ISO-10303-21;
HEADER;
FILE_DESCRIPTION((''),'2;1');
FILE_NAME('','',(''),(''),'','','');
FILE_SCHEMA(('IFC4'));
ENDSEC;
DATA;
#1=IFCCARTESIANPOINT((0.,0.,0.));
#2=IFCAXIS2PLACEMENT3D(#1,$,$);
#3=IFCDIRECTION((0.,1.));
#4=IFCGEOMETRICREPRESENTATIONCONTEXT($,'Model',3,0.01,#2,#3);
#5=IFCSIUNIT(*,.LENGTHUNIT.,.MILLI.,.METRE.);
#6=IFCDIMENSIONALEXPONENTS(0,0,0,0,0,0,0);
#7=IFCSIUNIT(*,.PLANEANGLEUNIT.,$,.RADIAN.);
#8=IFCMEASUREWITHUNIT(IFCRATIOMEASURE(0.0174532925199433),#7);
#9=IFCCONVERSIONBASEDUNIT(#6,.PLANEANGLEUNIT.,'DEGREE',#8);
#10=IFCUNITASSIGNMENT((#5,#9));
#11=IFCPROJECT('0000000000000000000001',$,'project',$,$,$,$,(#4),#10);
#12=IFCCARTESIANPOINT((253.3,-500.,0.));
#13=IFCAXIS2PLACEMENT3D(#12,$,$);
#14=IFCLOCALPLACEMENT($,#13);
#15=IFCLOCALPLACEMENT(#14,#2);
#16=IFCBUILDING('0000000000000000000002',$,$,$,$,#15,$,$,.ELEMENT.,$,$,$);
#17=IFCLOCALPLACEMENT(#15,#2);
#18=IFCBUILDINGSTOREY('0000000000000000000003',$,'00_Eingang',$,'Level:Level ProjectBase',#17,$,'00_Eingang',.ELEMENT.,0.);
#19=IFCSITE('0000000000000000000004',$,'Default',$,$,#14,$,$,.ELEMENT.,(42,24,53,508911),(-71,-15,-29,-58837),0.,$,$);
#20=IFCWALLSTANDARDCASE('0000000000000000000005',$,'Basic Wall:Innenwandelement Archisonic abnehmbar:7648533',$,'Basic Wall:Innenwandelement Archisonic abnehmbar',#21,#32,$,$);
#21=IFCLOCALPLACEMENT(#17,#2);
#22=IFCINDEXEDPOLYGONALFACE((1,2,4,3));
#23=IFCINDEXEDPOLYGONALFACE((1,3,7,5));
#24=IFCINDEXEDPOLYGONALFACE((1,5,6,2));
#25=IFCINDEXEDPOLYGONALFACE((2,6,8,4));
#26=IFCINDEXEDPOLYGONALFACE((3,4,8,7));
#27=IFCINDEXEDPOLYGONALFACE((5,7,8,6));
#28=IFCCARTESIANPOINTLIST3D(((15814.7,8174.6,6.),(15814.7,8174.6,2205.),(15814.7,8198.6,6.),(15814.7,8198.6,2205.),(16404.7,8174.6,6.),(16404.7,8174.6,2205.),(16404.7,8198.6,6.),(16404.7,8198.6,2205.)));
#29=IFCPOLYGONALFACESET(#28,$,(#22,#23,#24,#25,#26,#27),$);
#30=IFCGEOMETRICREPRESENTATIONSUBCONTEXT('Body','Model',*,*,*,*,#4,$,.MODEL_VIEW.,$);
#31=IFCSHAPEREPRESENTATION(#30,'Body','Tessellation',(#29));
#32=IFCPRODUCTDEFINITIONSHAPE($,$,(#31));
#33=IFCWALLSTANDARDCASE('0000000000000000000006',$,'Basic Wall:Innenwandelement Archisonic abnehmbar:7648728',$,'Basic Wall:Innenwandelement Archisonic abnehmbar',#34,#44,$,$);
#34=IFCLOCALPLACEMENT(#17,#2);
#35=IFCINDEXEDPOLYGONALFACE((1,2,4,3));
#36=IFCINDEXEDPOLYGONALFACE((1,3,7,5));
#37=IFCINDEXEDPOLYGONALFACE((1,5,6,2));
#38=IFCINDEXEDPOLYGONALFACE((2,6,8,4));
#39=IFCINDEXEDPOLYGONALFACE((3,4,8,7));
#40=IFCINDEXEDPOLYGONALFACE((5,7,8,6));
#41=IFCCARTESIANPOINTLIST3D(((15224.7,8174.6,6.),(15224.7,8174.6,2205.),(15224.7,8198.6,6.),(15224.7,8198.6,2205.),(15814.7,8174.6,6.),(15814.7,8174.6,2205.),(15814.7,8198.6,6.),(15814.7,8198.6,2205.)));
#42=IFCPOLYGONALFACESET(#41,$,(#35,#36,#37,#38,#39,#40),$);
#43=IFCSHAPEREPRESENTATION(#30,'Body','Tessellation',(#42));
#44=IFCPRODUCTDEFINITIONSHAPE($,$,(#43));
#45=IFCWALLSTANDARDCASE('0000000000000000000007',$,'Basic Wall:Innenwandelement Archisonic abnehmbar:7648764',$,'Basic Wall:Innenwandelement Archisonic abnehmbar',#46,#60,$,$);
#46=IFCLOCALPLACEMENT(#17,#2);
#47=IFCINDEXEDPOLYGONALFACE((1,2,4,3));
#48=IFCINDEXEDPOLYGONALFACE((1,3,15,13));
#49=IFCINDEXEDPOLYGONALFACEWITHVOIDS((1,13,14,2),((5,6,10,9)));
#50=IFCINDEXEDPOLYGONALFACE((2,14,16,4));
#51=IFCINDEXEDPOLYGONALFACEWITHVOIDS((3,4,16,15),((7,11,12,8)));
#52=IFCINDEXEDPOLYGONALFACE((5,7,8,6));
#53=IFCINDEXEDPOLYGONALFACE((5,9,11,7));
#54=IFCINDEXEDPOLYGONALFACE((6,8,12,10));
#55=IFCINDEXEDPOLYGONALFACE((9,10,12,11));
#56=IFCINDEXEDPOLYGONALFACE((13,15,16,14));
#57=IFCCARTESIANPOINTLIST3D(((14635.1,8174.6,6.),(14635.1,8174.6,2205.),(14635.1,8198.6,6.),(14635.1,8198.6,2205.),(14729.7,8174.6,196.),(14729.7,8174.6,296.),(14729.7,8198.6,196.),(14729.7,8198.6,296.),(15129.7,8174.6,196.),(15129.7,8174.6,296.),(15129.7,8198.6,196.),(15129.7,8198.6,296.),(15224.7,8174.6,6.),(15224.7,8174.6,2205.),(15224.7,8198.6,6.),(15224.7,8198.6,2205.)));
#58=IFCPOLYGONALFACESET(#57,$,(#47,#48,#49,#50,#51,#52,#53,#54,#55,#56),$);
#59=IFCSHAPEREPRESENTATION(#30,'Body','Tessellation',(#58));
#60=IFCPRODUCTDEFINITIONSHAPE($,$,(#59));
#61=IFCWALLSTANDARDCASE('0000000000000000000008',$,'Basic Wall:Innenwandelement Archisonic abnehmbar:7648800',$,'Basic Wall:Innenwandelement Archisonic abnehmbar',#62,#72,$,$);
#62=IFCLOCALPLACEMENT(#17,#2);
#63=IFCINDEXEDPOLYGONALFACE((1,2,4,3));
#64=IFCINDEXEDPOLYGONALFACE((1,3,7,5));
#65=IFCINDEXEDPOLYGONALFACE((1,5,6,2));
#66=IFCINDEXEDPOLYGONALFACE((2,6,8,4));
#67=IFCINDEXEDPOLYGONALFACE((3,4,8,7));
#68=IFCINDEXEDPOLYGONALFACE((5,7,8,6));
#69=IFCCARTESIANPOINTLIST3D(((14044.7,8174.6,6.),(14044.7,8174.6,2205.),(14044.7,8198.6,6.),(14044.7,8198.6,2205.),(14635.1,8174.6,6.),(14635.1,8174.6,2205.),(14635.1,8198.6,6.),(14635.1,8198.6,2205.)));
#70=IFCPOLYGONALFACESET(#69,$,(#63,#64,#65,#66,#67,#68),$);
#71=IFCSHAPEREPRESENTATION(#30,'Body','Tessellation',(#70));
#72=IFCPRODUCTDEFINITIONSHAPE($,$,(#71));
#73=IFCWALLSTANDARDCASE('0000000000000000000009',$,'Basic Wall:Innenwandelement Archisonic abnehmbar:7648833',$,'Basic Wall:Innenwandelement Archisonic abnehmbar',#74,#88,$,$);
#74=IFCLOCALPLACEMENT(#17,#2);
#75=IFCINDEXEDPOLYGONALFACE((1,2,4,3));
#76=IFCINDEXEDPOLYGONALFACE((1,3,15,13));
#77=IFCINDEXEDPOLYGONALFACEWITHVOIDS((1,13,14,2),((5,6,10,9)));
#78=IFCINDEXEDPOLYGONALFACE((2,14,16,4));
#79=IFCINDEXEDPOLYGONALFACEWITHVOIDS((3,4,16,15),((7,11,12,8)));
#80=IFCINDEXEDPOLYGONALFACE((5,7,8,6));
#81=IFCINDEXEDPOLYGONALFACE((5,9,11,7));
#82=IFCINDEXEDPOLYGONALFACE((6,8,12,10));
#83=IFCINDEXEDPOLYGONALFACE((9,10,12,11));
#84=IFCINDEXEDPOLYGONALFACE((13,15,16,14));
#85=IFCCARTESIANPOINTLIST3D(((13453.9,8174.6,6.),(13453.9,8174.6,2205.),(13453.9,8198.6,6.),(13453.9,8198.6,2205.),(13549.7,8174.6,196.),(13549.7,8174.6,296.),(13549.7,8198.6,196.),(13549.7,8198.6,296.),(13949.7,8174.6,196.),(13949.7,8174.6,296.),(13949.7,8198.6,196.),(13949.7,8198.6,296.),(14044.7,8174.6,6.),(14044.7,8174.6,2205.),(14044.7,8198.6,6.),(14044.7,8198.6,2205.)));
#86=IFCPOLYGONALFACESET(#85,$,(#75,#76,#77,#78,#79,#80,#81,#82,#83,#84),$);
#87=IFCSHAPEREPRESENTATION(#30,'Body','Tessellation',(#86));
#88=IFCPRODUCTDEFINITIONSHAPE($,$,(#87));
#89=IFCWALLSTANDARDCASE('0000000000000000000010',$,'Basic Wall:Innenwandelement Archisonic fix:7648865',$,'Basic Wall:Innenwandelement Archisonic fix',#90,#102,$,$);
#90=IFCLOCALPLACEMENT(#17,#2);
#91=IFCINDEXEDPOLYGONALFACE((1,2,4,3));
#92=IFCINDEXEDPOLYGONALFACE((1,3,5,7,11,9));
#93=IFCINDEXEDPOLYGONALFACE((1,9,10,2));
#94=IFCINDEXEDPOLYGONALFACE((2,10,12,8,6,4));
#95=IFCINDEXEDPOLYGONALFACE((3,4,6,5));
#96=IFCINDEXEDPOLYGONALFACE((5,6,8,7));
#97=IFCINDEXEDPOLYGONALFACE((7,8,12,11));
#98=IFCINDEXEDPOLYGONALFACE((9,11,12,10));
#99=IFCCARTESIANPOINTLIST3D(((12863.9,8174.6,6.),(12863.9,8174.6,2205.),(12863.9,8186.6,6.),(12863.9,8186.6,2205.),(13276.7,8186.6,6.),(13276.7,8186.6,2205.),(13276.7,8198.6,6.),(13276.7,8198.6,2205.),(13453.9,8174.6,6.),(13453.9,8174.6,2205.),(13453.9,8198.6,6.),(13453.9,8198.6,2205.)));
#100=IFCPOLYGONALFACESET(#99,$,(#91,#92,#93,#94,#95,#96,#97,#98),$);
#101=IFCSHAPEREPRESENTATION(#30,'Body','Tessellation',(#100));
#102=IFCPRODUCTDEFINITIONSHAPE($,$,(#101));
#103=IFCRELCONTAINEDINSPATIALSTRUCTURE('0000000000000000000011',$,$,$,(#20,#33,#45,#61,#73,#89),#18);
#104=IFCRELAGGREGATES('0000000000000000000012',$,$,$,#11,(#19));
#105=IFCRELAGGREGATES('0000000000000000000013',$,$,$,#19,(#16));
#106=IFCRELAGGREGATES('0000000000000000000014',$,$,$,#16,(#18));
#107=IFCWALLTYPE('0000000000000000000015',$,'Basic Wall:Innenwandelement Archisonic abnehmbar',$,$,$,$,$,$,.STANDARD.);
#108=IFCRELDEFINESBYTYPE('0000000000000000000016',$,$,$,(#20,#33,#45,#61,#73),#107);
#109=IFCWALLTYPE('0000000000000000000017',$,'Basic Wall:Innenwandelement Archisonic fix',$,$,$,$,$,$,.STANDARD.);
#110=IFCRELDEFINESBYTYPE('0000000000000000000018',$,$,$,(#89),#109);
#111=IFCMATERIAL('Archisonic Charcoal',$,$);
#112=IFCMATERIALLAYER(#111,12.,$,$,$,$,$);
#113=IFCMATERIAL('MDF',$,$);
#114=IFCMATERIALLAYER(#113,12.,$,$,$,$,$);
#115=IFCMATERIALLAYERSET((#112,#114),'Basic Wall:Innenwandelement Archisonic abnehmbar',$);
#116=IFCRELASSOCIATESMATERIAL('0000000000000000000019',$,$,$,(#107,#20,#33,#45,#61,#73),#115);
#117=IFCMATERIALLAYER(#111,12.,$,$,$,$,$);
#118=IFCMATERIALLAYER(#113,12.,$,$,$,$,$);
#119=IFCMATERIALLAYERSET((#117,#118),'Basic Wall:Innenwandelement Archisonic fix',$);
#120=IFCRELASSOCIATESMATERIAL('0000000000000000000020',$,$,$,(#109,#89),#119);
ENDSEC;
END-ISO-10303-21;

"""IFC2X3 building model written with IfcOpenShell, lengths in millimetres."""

from ifc_helpers import new_model, entity, si_unit, converted_unit, direction, frame, frame_2d, origin, origin_2d_with_axis, place, context, subcontext, project, spatial, polyline, rectangle, extrude, clip, bounded_halfspace, material, layer, layer_set, layer_usage, type_object, element, save


model = new_model("IFC2X3")

# Units and contexts
model_context = context("Model", 3, precision=0.01, world=origin(), true_north=direction((0.0, 1.0)))
body_context = subcontext(model_context, "Body", "Model", "MODEL_VIEW")
ifc_project = project(units=[si_unit("LENGTHUNIT", "METRE", prefix="MILLI"), converted_unit("PLANEANGLEUNIT", "DEGREE", entity("IfcRatioMeasure", 0.0174532925199433), si_unit("PLANEANGLEUNIT", "RADIAN"), dimensions=[0, 0, 0, 0, 0, 0, 0])], contexts=[model_context])

# Site, building, storey
site_placement = place(None, frame((253.3, -500.0, 0.0)))
site = spatial("IfcSite", under=ifc_project, at=site_placement, Name="Default", CompositionType="ELEMENT", RefLatitude=(42, 24, 53, 508911), RefLongitude=(-71, -15, -29, -58837), RefElevation=0.0)
building_placement = place(site_placement, origin())
building = spatial("IfcBuilding", under=site, at=building_placement, CompositionType="ELEMENT")
storey_placement = place(building_placement, origin())
storey = spatial("IfcBuildingStorey", under=building, at=storey_placement, Name="00_Eingang", ObjectType="Level:Level ProjectBase", LongName="00_Eingang", CompositionType="ELEMENT", Elevation=0.0)

# Shared definitions
ifc_material_1 = material(Name="Archisonic Charcoal")
ifc_layer_1 = layer(ifc_material_1, 12.0)
ifc_material_2 = material(Name="MDF")
ifc_layer_2 = layer(ifc_material_2, 12.0)
ifc_layer_set_1 = layer_set([ifc_layer_1, ifc_layer_2], Name="Basic Wall:Innenwandelement Archisonic abnehmbar")
wall_type_1 = type_object("IfcWallType", Name="Basic Wall:Innenwandelement Archisonic abnehmbar", PredefinedType="STANDARD", material=ifc_layer_set_1)

# Walls
ifc_layer_usage_1 = layer_usage(ifc_layer_set_1, "AXIS2", "POSITIVE", -12.0)
wall_1_placement = place(storey_placement, frame((15814.7, 8186.6, 6.0)))
element("IfcWallStandardCase", 1, at=wall_1_placement, inside=storey, type_object=wall_type_1, material=ifc_layer_usage_1, Name="Basic Wall:Innenwandelement Archisonic abnehmbar:7648533", ObjectType="Basic Wall:Innenwandelement Archisonic abnehmbar", context=body_context, shape_type="SweptSolid", body=[
    extrude(rectangle(XDim=590.0, YDim=24.0, at=frame_2d((295.0, 0.0), x_axis=(-1.0, 0.0))), origin(), (0.0, 0.0, 1.0), 2199.0),
])
ifc_layer_usage_2 = layer_usage(ifc_layer_set_1, "AXIS2", "NEGATIVE", 12.0)
wall_2_placement = place(storey_placement, frame((15814.7, 8186.6, 6.0), z_axis=(0.0, 0.0, 1.0), x_axis=(-1.0, 0.0, 0.0)))
element("IfcWallStandardCase", 2, at=wall_2_placement, inside=storey, type_object=wall_type_1, material=ifc_layer_usage_2, Name="Basic Wall:Innenwandelement Archisonic abnehmbar:7648728", ObjectType="Basic Wall:Innenwandelement Archisonic abnehmbar", context=body_context, shape_type="SweptSolid", body=[
    extrude(rectangle(XDim=590.0, YDim=24.0, at=frame_2d((295.0, 0.0), x_axis=(-1.0, 0.0))), origin(), (0.0, 0.0, 1.0), 2199.0),
])

# Wall, opening
ifc_layer_usage_3 = layer_usage(ifc_layer_set_1, "AXIS2", "POSITIVE", -12.0)
wall_3_placement = place(storey_placement, frame((14635.1, 8186.6, 6.0)))
wall_3 = element("IfcWallStandardCase", 3, at=wall_3_placement, inside=storey, type_object=wall_type_1, material=ifc_layer_usage_3, Name="Basic Wall:Innenwandelement Archisonic abnehmbar:7648764", ObjectType="Basic Wall:Innenwandelement Archisonic abnehmbar", context=body_context, shape_type="SweptSolid", body=[
    extrude(rectangle(XDim=589.6, YDim=24.0, at=frame_2d((294.8, 0.0), x_axis=(-1.0, 0.0))), origin(), (0.0, 0.0, 1.0), 2199.0),
])
opening_1_placement = place(wall_3_placement, frame((94.6, -70.0, 190.0)))
element("IfcOpeningElement", 4, at=opening_1_placement, cuts=wall_3, ObjectType="Opening", context=body_context, shape_type="SweptSolid", body=[
    extrude(rectangle(XDim=100.0, YDim=400.0, at=origin_2d_with_axis()), frame((200.0, 0.0, 50.0), z_axis=(0.0, 1.0, 0.0), x_axis=(0.0, 0.0, 1.0)), (0.0, 0.0, 1.0), 200.0),
])

# Wall
ifc_layer_usage_4 = layer_usage(ifc_layer_set_1, "AXIS2", "NEGATIVE", 12.0)
wall_4_placement = place(storey_placement, frame((14635.1, 8186.6, 6.0), z_axis=(0.0, 0.0, 1.0), x_axis=(-1.0, 0.0, 0.0)))
element("IfcWallStandardCase", 5, at=wall_4_placement, inside=storey, type_object=wall_type_1, material=ifc_layer_usage_4, Name="Basic Wall:Innenwandelement Archisonic abnehmbar:7648800", ObjectType="Basic Wall:Innenwandelement Archisonic abnehmbar", context=body_context, shape_type="SweptSolid", body=[
    extrude(rectangle(XDim=590.4, YDim=24.0, at=frame_2d((295.2, 0.0), x_axis=(-1.0, 0.0))), origin(), (0.0, 0.0, 1.0), 2199.0),
])

# Wall, opening
ifc_layer_usage_5 = layer_usage(ifc_layer_set_1, "AXIS2", "POSITIVE", -12.0)
wall_5_placement = place(storey_placement, frame((13453.9, 8186.6, 6.0)))
wall_5 = element("IfcWallStandardCase", 6, at=wall_5_placement, inside=storey, type_object=wall_type_1, material=ifc_layer_usage_5, Name="Basic Wall:Innenwandelement Archisonic abnehmbar:7648833", ObjectType="Basic Wall:Innenwandelement Archisonic abnehmbar", context=body_context, shape_type="SweptSolid", body=[
    extrude(rectangle(XDim=590.8, YDim=24.0, at=frame_2d((295.4, 0.0), x_axis=(-1.0, 0.0))), origin(), (0.0, 0.0, 1.0), 2199.0),
])
opening_2_placement = place(wall_5_placement, frame((95.8, -70.0, 190.0)))
element("IfcOpeningElement", 7, at=opening_2_placement, cuts=wall_5, ObjectType="Opening", context=body_context, shape_type="SweptSolid", body=[
    extrude(rectangle(XDim=100.0, YDim=400.0, at=origin_2d_with_axis()), frame((200.0, 0.0, 50.0), z_axis=(0.0, 1.0, 0.0), x_axis=(0.0, 0.0, 1.0)), (0.0, 0.0, 1.0), 200.0),
])

# Wall
ifc_layer_3 = layer(ifc_material_1, 12.0)
ifc_layer_4 = layer(ifc_material_2, 12.0)
ifc_layer_set_2 = layer_set([ifc_layer_3, ifc_layer_4], Name="Basic Wall:Innenwandelement Archisonic fix")
ifc_layer_usage_6 = layer_usage(ifc_layer_set_2, "AXIS2", "NEGATIVE", 12.0)
wall_type_2 = type_object("IfcWallType", Name="Basic Wall:Innenwandelement Archisonic fix", PredefinedType="STANDARD", material=ifc_layer_set_2)
wall_6_placement = place(storey_placement, frame((13453.9, 8186.6, 6.0), z_axis=(0.0, 0.0, 1.0), x_axis=(-1.0, 0.0, 0.0)))
element("IfcWallStandardCase", 8, at=wall_6_placement, inside=storey, type_object=wall_type_2, material=ifc_layer_usage_6, Name="Basic Wall:Innenwandelement Archisonic fix:7648865", ObjectType="Basic Wall:Innenwandelement Archisonic fix", context=body_context, shape_type="Clipping", body=[
    clip(clip(extrude(rectangle(XDim=590.0, YDim=24.0, at=frame_2d((295.0, 0.0), x_axis=(-1.0, 0.0))), origin(), (0.0, 0.0, 1.0), 2199.0), bounded_halfspace(frame((177.3, 0.0, 2199.0), z_axis=(0.0, 1.0, 0.0), x_axis=(-1.0, 0.0, 0.0)), True, frame((177.3, 0.0, 2199.0), z_axis=(0.0, 1.0, 0.0), x_axis=(-1.0, 0.0, 0.0)), polyline([(0.0, 0.0), (-412.7, 0.0), (-412.7, -2199.0), (0.0, -2199.0), (0.0, 0.0)]))), bounded_halfspace(frame((177.3, 0.0, 0.0), z_axis=(-1.0, 0.0, 0.0), x_axis=(0.0, -1.0, 0.0)), True, frame((177.3, 0.0, 0.0), z_axis=(-1.0, 0.0, 0.0), x_axis=(0.0, -1.0, 0.0)), polyline([(0.0, 0.0), (12.0, 0.0), (12.0, 2199.0), (0.0, 2199.0), (0.0, 0.0)]))),
])

save(model, "model.ifc")
